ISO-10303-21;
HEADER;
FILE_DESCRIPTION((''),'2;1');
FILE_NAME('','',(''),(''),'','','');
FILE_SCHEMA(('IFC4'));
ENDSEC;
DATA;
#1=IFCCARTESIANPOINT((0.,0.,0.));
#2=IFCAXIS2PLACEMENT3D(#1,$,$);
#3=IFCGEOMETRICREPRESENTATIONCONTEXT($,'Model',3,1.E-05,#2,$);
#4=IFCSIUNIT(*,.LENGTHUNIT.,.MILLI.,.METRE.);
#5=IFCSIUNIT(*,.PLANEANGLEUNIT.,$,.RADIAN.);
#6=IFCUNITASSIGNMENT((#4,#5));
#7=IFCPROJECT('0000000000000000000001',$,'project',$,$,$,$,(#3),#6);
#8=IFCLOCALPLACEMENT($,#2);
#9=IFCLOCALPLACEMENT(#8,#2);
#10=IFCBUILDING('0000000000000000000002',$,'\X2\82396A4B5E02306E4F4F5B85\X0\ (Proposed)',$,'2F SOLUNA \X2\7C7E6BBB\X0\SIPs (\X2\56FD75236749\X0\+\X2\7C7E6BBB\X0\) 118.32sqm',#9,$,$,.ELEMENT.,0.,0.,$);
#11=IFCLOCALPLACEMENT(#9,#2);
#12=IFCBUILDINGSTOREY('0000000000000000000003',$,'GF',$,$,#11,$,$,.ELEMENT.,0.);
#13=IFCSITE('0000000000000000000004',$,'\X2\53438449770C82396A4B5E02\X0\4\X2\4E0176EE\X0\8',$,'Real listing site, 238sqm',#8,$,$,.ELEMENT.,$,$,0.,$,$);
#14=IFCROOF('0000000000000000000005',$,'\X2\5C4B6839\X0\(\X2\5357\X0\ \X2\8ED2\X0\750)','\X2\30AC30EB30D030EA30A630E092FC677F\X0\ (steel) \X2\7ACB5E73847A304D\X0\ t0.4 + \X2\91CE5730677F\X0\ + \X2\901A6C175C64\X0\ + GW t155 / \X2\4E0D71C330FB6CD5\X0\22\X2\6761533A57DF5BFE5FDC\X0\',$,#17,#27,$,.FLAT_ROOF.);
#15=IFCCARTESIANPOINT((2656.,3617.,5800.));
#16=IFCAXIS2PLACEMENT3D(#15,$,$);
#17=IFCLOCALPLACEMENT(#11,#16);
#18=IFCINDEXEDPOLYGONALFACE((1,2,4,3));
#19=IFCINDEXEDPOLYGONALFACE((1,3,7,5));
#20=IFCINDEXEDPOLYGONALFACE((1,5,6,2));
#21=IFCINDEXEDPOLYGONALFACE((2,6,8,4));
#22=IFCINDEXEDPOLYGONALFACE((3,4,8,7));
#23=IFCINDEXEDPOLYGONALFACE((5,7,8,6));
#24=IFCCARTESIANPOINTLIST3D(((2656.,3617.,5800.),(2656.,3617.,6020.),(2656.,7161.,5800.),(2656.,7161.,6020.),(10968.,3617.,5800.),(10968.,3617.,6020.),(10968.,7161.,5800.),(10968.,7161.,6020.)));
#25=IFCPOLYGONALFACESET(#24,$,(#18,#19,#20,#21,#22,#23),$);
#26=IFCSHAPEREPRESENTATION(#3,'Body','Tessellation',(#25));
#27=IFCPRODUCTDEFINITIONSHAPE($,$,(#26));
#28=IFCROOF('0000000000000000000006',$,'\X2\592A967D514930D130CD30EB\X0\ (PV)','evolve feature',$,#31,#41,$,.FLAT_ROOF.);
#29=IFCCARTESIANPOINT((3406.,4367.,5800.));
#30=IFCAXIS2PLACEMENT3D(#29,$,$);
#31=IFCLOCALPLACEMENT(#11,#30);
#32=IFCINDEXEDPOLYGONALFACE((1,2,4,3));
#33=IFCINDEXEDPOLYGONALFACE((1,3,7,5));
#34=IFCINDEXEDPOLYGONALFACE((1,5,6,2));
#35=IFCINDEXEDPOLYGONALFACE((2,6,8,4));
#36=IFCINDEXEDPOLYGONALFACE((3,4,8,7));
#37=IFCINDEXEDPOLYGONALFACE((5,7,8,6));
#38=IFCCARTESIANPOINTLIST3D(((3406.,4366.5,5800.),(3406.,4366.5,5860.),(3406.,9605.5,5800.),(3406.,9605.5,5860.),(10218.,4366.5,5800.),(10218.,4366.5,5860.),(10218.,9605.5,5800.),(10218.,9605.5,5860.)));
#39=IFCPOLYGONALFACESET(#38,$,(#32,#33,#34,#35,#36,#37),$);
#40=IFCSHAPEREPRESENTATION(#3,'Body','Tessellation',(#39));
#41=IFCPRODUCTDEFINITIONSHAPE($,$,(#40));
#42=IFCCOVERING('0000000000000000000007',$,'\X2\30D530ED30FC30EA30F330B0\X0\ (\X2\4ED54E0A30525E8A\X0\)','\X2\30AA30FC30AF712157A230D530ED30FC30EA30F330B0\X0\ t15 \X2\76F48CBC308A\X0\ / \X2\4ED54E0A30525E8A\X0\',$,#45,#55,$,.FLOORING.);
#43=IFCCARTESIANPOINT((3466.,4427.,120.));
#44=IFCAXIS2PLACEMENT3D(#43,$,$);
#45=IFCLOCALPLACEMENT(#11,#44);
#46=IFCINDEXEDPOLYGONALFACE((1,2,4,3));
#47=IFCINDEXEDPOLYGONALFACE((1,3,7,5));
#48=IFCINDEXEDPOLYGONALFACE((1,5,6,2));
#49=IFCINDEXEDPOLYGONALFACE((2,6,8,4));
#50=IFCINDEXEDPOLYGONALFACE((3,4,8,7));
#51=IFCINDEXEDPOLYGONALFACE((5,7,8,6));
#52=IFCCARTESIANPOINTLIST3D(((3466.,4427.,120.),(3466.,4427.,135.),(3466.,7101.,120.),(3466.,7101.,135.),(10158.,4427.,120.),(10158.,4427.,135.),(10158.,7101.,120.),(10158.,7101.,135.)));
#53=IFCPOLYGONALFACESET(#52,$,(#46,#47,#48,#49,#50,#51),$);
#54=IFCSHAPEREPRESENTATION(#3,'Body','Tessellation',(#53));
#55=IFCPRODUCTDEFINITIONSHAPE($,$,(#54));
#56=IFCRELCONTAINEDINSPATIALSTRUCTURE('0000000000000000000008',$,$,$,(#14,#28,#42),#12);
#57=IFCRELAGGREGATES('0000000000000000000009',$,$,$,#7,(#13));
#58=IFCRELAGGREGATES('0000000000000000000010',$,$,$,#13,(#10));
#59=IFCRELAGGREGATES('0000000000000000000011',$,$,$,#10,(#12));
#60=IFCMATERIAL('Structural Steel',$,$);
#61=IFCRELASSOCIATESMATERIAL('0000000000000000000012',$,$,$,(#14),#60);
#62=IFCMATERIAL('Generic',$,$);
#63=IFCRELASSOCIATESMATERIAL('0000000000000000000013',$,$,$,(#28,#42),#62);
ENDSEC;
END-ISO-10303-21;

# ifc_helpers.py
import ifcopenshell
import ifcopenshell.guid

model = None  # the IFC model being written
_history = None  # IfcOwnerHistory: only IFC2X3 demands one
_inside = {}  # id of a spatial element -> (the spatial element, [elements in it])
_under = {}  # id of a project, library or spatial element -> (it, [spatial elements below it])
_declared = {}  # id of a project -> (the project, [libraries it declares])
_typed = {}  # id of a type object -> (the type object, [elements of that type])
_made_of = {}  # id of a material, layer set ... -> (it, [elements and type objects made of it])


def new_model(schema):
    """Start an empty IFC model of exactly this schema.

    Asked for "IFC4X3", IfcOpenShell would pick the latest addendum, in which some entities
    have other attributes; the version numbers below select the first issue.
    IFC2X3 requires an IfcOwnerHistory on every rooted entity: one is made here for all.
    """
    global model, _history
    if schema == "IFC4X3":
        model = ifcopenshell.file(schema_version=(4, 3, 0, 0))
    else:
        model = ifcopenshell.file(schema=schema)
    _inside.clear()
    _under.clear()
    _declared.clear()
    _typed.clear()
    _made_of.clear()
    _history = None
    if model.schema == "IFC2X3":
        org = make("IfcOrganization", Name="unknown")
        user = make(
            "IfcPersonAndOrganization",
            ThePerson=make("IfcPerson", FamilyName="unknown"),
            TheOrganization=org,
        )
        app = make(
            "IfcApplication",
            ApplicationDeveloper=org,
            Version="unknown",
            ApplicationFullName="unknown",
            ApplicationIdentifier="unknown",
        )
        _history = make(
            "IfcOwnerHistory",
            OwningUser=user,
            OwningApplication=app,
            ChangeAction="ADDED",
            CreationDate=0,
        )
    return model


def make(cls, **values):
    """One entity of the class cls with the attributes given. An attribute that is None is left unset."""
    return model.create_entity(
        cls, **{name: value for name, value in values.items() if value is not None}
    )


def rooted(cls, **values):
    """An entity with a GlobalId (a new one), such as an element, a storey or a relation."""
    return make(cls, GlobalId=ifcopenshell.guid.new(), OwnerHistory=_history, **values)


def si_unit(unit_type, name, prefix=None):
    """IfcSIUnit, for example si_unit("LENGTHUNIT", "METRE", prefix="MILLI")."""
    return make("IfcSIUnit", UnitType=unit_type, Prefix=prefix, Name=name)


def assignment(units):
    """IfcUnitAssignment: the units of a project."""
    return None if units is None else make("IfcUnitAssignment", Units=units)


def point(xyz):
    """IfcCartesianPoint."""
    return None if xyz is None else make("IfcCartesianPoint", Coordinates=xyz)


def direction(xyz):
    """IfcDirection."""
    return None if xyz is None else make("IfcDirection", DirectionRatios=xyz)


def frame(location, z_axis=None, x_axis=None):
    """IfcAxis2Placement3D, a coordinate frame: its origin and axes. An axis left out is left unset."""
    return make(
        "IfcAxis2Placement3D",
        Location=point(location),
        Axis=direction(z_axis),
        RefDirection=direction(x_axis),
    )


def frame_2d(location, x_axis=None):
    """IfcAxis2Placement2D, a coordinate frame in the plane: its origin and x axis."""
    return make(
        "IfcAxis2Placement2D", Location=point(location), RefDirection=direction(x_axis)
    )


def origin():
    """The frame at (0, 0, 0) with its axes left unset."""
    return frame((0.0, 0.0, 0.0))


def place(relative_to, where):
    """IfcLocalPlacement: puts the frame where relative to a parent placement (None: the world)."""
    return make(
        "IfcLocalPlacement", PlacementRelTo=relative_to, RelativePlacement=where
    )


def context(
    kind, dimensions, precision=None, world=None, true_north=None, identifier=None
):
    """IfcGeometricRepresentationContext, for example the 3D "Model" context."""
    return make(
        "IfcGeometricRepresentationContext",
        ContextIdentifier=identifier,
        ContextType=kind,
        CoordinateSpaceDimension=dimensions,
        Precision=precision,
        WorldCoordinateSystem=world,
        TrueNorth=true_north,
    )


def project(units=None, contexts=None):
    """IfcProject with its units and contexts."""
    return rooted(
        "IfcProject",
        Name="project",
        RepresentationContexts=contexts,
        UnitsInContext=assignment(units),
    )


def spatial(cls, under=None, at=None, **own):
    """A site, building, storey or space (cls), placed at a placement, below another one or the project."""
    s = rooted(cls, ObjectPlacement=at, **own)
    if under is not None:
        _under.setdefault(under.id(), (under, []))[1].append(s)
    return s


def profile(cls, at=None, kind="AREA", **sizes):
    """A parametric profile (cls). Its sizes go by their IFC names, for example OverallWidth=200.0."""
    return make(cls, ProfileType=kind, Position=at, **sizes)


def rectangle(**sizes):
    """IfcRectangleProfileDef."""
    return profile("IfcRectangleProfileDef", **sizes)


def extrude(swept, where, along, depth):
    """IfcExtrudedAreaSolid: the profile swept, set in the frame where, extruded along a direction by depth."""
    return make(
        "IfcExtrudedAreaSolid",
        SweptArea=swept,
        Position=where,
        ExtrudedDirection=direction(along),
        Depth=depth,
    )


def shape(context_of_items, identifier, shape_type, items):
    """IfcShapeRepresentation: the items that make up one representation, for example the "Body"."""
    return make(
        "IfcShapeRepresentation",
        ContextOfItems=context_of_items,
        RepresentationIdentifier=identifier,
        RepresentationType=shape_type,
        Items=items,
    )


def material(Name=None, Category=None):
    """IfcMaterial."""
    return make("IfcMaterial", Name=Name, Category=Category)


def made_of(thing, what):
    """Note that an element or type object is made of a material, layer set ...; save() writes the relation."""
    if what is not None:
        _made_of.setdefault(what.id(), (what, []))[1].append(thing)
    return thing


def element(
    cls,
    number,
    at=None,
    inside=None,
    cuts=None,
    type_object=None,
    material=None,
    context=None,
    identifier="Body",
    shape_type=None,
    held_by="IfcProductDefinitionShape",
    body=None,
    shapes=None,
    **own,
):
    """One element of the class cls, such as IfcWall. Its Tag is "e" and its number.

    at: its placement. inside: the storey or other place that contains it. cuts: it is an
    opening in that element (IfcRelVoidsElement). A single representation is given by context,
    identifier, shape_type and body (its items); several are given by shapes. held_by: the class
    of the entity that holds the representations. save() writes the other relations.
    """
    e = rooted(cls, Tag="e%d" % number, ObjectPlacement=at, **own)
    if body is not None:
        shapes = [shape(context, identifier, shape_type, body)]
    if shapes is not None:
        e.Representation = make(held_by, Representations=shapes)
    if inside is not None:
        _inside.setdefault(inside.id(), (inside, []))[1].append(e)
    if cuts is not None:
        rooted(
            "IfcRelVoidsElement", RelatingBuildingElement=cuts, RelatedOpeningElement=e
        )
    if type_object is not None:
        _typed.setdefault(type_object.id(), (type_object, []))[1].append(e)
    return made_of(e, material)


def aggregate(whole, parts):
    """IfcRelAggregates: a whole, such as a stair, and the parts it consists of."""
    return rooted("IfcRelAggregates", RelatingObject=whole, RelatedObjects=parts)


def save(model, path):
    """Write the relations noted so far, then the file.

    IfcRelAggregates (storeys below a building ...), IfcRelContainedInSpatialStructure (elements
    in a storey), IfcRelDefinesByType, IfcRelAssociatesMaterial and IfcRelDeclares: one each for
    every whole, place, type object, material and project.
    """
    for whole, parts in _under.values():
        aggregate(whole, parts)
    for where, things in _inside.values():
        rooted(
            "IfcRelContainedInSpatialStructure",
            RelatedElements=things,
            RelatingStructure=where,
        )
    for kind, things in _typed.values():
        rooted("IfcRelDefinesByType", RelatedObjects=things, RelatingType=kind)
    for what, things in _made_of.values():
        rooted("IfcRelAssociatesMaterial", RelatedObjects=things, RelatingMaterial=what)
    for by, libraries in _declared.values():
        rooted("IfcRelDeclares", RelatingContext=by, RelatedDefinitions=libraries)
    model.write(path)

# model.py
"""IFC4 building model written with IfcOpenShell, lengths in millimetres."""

from ifc_helpers import new_model, si_unit, frame, frame_2d, origin, place, context, project, spatial, rectangle, extrude, material, element, save


model = new_model("IFC4")

# Units and contexts
model_context = context("Model", 3, precision=1e-05, world=origin())
ifc_project = project(units=[si_unit("LENGTHUNIT", "METRE", prefix="MILLI"), si_unit("PLANEANGLEUNIT", "RADIAN")], contexts=[model_context])

# Site, building, storey
site_placement = place(None, origin())
site = spatial("IfcSite", under=ifc_project, at=site_placement, Name="千葉県船橋市4丁目8", ObjectType="Real listing site, 238sqm", CompositionType="ELEMENT", RefElevation=0.0)
building_placement = place(site_placement, origin())
building = spatial("IfcBuilding", under=site, at=building_placement, Name="船橋市の住宅 (Proposed)", ObjectType="2F SOLUNA 籾殻SIPs (国産杉+籾殻) 118.32sqm", CompositionType="ELEMENT", ElevationOfRefHeight=0.0, ElevationOfTerrain=0.0)
storey_placement = place(building_placement, origin())
storey = spatial("IfcBuildingStorey", under=building, at=storey_placement, Name="GF", CompositionType="ELEMENT", Elevation=0.0)

# Shared definitions
ifc_material_1 = material(Name="Generic")

# Roofs
ifc_material_2 = material(Name="Structural Steel")
roof_1_placement = place(storey_placement, frame((2656.0, 3617.0, 5800.0)))
element("IfcRoof", 1, at=roof_1_placement, inside=storey, material=ifc_material_2, Name="屋根(南 軒750)", Description="ガルバリウム鋼板 (steel) 立平葺き t0.4 + 野地板 + 通気層 + GW t155 / 不燃・法22条区域対応", PredefinedType="FLAT_ROOF", context=model_context, shape_type="SweptSolid", body=[
    extrude(rectangle(XDim=8312.0, YDim=3544.0, at=frame_2d((4156.0, 1772.0))), frame((2656.0, 3617.0, 5800.0)), (0.0, 0.0, 1.0), 220.0),
])
roof_2_placement = place(storey_placement, frame((3406.0, 4367.0, 5800.0)))
element("IfcRoof", 2, at=roof_2_placement, inside=storey, material=ifc_material_1, Name="太陽光パネル (PV)", Description="evolve feature", PredefinedType="FLAT_ROOF", context=model_context, shape_type="SweptSolid", body=[
    extrude(rectangle(XDim=6812.0, YDim=5239.0, at=frame_2d((3406.0, 2619.0))), frame((3406.0, 4367.0, 5800.0)), (0.0, 0.0, 1.0), 60.0),
])

# Covering
covering_placement = place(storey_placement, frame((3466.0, 4427.0, 120.0)))
element("IfcCovering", 3, at=covering_placement, inside=storey, material=ifc_material_1, Name="フローリング (仕上げ床)", Description="オーク無垢フローリング t15 直貼り / 仕上げ床", PredefinedType="FLOORING", context=model_context, shape_type="SweptSolid", body=[
    extrude(rectangle(XDim=6692.0, YDim=2674.0, at=frame_2d((3346.0, 1337.0))), frame((3466.0, 4427.0, 120.0)), (0.0, 0.0, 1.0), 15.0),
])

save(model, "model.ifc")
